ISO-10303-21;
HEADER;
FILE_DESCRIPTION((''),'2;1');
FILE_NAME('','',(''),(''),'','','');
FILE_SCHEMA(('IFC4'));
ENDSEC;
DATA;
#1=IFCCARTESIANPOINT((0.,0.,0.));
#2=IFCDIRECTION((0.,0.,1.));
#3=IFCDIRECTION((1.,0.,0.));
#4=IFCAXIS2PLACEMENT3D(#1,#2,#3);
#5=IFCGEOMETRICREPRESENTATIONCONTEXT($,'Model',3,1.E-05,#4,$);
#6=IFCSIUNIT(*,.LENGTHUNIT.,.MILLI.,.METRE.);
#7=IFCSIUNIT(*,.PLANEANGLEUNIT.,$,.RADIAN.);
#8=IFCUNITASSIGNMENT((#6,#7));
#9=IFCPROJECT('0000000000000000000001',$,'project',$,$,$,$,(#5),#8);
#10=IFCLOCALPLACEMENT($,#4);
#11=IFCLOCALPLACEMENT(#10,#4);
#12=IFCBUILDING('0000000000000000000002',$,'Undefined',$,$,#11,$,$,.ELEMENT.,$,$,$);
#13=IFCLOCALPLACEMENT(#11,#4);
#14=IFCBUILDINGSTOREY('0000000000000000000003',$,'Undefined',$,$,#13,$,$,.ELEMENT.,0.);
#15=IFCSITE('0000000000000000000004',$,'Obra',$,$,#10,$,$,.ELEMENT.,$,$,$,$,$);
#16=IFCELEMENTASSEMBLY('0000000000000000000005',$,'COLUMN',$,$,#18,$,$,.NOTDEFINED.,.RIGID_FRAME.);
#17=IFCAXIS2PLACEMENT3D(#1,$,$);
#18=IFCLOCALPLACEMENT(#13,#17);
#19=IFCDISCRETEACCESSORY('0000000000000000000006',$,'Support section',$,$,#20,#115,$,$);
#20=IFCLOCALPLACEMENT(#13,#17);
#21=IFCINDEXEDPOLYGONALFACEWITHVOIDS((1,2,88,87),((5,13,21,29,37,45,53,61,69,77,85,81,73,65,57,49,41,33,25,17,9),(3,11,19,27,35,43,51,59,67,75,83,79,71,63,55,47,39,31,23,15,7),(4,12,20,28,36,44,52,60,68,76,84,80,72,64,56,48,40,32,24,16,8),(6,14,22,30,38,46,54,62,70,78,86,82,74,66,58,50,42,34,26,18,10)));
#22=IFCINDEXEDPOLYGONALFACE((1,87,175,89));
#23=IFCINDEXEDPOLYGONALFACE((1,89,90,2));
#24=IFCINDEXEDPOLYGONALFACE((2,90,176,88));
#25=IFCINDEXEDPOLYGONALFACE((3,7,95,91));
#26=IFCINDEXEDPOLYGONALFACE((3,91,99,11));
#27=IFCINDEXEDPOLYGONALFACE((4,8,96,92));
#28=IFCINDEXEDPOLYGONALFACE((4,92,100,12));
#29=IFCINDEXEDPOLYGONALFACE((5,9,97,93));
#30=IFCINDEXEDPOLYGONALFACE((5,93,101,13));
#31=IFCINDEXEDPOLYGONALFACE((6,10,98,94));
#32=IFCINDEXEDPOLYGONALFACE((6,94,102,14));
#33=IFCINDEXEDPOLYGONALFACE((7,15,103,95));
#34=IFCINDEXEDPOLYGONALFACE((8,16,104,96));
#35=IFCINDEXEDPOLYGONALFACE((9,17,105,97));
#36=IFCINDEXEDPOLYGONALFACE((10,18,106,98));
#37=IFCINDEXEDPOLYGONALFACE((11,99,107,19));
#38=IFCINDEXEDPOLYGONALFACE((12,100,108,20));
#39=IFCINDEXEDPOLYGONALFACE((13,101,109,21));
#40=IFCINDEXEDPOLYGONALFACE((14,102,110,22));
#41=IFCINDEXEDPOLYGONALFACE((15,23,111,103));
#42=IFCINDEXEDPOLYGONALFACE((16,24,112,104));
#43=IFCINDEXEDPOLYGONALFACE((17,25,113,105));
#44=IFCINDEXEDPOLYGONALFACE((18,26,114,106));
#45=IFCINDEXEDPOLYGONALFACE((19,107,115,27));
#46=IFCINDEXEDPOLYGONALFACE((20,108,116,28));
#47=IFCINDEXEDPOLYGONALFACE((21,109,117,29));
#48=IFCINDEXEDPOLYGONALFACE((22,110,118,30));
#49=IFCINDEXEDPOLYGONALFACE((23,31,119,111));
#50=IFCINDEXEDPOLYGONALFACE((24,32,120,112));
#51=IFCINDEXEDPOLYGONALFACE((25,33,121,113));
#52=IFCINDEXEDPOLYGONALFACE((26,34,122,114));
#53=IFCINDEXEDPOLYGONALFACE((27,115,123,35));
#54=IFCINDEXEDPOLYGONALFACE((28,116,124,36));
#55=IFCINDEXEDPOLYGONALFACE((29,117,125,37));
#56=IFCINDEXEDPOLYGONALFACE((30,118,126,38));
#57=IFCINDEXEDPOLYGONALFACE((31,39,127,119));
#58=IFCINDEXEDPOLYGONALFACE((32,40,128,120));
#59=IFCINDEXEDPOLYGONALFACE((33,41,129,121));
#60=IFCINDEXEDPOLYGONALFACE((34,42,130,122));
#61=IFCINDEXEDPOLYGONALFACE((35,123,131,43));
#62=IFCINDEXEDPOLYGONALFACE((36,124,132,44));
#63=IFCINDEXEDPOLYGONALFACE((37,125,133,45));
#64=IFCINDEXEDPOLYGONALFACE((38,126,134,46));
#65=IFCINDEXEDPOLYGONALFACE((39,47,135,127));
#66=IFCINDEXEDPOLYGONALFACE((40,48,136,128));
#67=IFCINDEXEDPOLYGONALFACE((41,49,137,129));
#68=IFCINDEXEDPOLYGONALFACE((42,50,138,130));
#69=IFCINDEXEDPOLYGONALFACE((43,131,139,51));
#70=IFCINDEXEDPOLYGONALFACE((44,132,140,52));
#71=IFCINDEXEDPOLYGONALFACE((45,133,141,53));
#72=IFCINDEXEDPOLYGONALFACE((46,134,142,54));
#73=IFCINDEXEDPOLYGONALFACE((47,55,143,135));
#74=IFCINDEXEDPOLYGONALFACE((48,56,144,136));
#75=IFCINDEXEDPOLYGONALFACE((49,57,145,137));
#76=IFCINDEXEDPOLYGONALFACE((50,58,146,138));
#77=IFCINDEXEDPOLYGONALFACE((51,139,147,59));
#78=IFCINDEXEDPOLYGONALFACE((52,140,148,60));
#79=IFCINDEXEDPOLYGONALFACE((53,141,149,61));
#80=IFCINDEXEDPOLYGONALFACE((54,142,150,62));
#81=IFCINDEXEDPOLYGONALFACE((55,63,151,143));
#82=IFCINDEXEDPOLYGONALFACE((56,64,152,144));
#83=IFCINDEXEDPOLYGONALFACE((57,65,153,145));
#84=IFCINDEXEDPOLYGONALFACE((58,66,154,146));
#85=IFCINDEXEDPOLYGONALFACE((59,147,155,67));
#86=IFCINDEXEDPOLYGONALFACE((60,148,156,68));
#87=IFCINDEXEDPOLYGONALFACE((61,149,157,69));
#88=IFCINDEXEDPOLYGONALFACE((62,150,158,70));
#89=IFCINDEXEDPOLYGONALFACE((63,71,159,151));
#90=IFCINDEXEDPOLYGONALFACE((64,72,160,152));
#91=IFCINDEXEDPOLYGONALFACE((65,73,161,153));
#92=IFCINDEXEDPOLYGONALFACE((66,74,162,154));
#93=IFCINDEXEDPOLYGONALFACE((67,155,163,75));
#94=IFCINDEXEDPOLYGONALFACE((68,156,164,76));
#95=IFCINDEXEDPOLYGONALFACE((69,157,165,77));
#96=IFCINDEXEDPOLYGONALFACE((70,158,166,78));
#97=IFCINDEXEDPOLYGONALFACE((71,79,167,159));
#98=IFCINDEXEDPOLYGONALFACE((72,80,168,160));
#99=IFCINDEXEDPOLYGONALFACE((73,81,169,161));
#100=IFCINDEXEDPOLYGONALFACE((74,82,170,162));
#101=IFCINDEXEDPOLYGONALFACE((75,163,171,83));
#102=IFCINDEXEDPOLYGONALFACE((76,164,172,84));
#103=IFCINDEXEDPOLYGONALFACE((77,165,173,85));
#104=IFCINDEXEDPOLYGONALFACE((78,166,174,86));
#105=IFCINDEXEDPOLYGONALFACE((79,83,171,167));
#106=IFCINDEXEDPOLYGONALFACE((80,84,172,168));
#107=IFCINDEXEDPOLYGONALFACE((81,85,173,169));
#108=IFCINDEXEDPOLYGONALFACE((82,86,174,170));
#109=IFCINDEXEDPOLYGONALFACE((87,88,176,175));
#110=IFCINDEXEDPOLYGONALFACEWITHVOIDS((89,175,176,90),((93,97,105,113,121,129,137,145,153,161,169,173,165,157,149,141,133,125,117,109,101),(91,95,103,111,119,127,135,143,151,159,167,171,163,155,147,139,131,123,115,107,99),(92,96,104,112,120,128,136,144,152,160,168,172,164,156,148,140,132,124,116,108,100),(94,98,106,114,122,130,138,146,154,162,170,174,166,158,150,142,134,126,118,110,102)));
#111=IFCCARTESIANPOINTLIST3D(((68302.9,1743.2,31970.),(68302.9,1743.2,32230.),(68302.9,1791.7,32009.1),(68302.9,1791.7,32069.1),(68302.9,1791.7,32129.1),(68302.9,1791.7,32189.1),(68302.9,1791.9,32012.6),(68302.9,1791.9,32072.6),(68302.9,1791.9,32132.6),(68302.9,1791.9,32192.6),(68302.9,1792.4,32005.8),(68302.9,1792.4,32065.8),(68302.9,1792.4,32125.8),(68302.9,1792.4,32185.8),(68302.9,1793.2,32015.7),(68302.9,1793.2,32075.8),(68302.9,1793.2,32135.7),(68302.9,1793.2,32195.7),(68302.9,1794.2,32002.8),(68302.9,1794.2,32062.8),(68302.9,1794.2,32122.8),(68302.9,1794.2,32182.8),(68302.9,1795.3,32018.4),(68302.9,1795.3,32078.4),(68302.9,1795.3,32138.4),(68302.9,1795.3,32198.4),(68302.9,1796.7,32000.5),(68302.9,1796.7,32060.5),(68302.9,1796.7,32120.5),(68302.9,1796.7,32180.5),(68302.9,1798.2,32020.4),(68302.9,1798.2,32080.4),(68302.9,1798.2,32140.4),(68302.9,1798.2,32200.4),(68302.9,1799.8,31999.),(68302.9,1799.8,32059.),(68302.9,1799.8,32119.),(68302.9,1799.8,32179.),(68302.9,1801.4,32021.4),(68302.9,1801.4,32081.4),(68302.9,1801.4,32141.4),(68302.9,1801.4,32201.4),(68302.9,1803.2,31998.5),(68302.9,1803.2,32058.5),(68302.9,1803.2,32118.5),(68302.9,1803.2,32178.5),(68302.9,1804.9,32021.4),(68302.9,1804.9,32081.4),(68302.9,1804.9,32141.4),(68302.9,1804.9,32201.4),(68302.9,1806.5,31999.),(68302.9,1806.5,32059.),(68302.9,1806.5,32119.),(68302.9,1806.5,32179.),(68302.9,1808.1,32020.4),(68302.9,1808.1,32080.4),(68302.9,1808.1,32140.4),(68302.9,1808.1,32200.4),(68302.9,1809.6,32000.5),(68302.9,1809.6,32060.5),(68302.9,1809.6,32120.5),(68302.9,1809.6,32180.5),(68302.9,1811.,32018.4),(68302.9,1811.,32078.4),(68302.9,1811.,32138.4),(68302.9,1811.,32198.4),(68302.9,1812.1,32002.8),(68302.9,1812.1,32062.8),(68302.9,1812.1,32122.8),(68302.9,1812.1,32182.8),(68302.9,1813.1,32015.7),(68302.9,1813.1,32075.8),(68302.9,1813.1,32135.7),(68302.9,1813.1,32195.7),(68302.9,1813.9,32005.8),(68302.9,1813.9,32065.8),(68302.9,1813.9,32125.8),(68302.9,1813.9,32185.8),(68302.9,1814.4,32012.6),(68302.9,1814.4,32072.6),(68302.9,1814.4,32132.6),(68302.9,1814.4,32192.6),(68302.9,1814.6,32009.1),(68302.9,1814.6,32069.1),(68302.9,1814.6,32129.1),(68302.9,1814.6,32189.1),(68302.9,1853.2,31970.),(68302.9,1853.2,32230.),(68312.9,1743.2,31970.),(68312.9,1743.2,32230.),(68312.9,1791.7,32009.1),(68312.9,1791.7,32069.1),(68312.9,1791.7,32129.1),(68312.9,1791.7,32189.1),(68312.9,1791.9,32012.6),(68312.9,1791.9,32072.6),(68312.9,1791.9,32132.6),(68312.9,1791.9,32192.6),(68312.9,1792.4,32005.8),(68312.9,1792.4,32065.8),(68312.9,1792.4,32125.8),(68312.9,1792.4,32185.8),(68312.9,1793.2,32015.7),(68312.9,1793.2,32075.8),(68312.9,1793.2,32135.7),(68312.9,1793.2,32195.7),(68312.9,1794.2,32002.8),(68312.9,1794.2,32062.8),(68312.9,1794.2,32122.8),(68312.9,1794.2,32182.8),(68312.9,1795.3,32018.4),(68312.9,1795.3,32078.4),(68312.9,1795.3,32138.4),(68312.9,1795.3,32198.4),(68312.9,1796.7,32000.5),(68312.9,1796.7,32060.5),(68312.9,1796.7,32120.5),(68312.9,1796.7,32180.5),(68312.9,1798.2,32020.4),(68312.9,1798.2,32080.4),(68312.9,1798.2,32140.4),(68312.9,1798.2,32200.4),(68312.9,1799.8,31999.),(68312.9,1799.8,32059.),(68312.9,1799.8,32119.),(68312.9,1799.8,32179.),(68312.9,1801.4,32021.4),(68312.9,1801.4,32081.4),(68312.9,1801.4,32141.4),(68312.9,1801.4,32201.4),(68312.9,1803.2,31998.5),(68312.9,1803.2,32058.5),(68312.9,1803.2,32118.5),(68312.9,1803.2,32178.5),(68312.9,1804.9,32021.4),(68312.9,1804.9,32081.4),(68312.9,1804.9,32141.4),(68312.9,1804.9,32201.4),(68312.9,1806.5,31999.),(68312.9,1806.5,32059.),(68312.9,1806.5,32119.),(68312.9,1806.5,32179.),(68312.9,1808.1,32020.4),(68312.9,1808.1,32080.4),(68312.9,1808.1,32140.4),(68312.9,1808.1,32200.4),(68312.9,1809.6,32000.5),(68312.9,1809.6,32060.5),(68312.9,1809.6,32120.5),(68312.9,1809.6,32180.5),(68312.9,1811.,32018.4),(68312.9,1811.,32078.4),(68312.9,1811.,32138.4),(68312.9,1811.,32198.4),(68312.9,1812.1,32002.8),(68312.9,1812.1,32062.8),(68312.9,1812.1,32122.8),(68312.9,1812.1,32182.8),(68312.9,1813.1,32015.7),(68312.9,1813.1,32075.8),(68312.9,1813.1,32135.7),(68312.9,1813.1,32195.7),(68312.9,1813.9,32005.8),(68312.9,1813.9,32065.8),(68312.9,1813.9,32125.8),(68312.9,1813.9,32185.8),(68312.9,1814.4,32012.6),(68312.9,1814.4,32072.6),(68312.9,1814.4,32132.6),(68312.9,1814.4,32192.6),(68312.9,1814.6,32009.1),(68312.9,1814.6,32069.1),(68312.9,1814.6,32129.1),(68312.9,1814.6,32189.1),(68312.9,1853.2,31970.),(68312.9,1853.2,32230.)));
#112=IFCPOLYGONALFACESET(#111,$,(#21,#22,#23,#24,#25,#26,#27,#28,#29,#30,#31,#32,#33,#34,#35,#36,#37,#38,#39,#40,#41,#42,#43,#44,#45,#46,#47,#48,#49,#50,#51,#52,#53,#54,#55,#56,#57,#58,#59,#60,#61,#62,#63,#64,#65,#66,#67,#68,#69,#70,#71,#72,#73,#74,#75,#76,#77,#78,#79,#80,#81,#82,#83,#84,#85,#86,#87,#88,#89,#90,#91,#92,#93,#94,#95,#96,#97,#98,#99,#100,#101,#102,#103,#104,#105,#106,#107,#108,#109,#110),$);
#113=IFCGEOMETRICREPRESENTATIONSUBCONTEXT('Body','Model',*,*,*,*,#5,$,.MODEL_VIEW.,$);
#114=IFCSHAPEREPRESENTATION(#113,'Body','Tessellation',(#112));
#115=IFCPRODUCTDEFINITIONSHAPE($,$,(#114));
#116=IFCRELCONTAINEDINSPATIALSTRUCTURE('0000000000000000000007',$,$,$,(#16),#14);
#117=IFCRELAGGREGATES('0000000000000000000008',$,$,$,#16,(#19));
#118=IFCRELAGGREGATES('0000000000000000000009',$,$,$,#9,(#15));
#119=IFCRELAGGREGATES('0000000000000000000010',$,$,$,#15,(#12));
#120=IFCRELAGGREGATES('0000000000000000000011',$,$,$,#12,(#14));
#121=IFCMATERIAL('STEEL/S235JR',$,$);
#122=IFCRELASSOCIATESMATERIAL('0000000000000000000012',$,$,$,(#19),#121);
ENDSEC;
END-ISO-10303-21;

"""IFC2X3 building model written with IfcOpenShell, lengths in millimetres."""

from ifc_helpers import new_model, si_unit, frame, origin_with_axes, origin_2d_with_axis, place, context, subcontext, project, spatial, rectangle, circle, extrude, source, transform, mapped, material, element, aggregate, save


model = new_model("IFC2X3")

# Units and contexts
model_context = context("Model", 3, precision=1e-05, world=origin_with_axes())
body_context = subcontext(model_context, "Body", "Model", "MODEL_VIEW")
ifc_project = project(units=[si_unit("LENGTHUNIT", "METRE", prefix="MILLI"), si_unit("PLANEANGLEUNIT", "RADIAN")], contexts=[model_context])

# Site, building, storey
site_placement = place(None, origin_with_axes())
site = spatial("IfcSite", under=ifc_project, at=site_placement, Name="Obra", CompositionType="ELEMENT")
building_placement = place(site_placement, origin_with_axes())
building = spatial("IfcBuilding", under=site, at=building_placement, Name="Undefined", CompositionType="ELEMENT")
storey_placement = place(building_placement, origin_with_axes())
storey = spatial("IfcBuildingStorey", under=building, at=storey_placement, Name="Undefined", CompositionType="ELEMENT", Elevation=0.0)

# Element assembly
assembly_1_placement = place(storey_placement, origin_with_axes())
assembly_1 = element("IfcElementAssembly", 1, at=assembly_1_placement, inside=storey, Name="COLUMN", AssemblyPlace="NOTDEFINED", PredefinedType="RIGID_FRAME")
ifc_material_1 = material(Name="STEEL/S235JR")

# Shared definitions
shared_shape_1 = source(origin_with_axes(), body_context, "Body", "SweptSolid", [
    extrude(circle(Radius=11.5, at=origin_2d_with_axis()), frame((0.0, -14.4, 0.0), z_axis=(0.0, 1.0, 0.0), x_axis=(1.0, 0.0, 0.0)), (0.0, 0.0, 1.0), 10.2),
])

# Discrete accessory, opening
discrete_accessory_1_placement = place(assembly_1_placement, frame((68307.9, 1798.2, 31970.0), z_axis=(0.0, 0.0, 1.0), x_axis=(0.0, -1.0, 0.0)))
discrete_accessory_1 = element("IfcDiscreteAccessory", 2, at=discrete_accessory_1_placement, material=ifc_material_1, Name="Support section", context=body_context, shape_type="SweptSolid", body=[
    extrude(rectangle(XDim=10.0, YDim=110.0, at=origin_2d_with_axis()), frame((0.0, 0.0, 260.0), z_axis=(0.0, 0.0, -1.0), x_axis=(0.0, 1.0, 0.0)), (0.0, 0.0, 1.0), 260.0),
])
opening_1_placement = place(assembly_1_placement, frame((68298.6, 1753.2, 32300.0), z_axis=(0.0, 1.0, 0.0), x_axis=(0.0, 0.0, -1.0)))
element("IfcOpeningElement", 3, at=opening_1_placement, cuts=discrete_accessory_1, ObjectType="Opening", context=body_context, shape_type="MappedRepresentation", body=[
    mapped(shared_shape_1, transform((110.0, 0.0, 50.0))),
    mapped(shared_shape_1, transform((170.0, 0.0, 50.0))),
    mapped(shared_shape_1, transform((230.0, 0.0, 50.0))),
    mapped(shared_shape_1, transform((290.0, 0.0, 50.0))),
])
aggregate(assembly_1, [discrete_accessory_1])

save(model, "model.ifc")
